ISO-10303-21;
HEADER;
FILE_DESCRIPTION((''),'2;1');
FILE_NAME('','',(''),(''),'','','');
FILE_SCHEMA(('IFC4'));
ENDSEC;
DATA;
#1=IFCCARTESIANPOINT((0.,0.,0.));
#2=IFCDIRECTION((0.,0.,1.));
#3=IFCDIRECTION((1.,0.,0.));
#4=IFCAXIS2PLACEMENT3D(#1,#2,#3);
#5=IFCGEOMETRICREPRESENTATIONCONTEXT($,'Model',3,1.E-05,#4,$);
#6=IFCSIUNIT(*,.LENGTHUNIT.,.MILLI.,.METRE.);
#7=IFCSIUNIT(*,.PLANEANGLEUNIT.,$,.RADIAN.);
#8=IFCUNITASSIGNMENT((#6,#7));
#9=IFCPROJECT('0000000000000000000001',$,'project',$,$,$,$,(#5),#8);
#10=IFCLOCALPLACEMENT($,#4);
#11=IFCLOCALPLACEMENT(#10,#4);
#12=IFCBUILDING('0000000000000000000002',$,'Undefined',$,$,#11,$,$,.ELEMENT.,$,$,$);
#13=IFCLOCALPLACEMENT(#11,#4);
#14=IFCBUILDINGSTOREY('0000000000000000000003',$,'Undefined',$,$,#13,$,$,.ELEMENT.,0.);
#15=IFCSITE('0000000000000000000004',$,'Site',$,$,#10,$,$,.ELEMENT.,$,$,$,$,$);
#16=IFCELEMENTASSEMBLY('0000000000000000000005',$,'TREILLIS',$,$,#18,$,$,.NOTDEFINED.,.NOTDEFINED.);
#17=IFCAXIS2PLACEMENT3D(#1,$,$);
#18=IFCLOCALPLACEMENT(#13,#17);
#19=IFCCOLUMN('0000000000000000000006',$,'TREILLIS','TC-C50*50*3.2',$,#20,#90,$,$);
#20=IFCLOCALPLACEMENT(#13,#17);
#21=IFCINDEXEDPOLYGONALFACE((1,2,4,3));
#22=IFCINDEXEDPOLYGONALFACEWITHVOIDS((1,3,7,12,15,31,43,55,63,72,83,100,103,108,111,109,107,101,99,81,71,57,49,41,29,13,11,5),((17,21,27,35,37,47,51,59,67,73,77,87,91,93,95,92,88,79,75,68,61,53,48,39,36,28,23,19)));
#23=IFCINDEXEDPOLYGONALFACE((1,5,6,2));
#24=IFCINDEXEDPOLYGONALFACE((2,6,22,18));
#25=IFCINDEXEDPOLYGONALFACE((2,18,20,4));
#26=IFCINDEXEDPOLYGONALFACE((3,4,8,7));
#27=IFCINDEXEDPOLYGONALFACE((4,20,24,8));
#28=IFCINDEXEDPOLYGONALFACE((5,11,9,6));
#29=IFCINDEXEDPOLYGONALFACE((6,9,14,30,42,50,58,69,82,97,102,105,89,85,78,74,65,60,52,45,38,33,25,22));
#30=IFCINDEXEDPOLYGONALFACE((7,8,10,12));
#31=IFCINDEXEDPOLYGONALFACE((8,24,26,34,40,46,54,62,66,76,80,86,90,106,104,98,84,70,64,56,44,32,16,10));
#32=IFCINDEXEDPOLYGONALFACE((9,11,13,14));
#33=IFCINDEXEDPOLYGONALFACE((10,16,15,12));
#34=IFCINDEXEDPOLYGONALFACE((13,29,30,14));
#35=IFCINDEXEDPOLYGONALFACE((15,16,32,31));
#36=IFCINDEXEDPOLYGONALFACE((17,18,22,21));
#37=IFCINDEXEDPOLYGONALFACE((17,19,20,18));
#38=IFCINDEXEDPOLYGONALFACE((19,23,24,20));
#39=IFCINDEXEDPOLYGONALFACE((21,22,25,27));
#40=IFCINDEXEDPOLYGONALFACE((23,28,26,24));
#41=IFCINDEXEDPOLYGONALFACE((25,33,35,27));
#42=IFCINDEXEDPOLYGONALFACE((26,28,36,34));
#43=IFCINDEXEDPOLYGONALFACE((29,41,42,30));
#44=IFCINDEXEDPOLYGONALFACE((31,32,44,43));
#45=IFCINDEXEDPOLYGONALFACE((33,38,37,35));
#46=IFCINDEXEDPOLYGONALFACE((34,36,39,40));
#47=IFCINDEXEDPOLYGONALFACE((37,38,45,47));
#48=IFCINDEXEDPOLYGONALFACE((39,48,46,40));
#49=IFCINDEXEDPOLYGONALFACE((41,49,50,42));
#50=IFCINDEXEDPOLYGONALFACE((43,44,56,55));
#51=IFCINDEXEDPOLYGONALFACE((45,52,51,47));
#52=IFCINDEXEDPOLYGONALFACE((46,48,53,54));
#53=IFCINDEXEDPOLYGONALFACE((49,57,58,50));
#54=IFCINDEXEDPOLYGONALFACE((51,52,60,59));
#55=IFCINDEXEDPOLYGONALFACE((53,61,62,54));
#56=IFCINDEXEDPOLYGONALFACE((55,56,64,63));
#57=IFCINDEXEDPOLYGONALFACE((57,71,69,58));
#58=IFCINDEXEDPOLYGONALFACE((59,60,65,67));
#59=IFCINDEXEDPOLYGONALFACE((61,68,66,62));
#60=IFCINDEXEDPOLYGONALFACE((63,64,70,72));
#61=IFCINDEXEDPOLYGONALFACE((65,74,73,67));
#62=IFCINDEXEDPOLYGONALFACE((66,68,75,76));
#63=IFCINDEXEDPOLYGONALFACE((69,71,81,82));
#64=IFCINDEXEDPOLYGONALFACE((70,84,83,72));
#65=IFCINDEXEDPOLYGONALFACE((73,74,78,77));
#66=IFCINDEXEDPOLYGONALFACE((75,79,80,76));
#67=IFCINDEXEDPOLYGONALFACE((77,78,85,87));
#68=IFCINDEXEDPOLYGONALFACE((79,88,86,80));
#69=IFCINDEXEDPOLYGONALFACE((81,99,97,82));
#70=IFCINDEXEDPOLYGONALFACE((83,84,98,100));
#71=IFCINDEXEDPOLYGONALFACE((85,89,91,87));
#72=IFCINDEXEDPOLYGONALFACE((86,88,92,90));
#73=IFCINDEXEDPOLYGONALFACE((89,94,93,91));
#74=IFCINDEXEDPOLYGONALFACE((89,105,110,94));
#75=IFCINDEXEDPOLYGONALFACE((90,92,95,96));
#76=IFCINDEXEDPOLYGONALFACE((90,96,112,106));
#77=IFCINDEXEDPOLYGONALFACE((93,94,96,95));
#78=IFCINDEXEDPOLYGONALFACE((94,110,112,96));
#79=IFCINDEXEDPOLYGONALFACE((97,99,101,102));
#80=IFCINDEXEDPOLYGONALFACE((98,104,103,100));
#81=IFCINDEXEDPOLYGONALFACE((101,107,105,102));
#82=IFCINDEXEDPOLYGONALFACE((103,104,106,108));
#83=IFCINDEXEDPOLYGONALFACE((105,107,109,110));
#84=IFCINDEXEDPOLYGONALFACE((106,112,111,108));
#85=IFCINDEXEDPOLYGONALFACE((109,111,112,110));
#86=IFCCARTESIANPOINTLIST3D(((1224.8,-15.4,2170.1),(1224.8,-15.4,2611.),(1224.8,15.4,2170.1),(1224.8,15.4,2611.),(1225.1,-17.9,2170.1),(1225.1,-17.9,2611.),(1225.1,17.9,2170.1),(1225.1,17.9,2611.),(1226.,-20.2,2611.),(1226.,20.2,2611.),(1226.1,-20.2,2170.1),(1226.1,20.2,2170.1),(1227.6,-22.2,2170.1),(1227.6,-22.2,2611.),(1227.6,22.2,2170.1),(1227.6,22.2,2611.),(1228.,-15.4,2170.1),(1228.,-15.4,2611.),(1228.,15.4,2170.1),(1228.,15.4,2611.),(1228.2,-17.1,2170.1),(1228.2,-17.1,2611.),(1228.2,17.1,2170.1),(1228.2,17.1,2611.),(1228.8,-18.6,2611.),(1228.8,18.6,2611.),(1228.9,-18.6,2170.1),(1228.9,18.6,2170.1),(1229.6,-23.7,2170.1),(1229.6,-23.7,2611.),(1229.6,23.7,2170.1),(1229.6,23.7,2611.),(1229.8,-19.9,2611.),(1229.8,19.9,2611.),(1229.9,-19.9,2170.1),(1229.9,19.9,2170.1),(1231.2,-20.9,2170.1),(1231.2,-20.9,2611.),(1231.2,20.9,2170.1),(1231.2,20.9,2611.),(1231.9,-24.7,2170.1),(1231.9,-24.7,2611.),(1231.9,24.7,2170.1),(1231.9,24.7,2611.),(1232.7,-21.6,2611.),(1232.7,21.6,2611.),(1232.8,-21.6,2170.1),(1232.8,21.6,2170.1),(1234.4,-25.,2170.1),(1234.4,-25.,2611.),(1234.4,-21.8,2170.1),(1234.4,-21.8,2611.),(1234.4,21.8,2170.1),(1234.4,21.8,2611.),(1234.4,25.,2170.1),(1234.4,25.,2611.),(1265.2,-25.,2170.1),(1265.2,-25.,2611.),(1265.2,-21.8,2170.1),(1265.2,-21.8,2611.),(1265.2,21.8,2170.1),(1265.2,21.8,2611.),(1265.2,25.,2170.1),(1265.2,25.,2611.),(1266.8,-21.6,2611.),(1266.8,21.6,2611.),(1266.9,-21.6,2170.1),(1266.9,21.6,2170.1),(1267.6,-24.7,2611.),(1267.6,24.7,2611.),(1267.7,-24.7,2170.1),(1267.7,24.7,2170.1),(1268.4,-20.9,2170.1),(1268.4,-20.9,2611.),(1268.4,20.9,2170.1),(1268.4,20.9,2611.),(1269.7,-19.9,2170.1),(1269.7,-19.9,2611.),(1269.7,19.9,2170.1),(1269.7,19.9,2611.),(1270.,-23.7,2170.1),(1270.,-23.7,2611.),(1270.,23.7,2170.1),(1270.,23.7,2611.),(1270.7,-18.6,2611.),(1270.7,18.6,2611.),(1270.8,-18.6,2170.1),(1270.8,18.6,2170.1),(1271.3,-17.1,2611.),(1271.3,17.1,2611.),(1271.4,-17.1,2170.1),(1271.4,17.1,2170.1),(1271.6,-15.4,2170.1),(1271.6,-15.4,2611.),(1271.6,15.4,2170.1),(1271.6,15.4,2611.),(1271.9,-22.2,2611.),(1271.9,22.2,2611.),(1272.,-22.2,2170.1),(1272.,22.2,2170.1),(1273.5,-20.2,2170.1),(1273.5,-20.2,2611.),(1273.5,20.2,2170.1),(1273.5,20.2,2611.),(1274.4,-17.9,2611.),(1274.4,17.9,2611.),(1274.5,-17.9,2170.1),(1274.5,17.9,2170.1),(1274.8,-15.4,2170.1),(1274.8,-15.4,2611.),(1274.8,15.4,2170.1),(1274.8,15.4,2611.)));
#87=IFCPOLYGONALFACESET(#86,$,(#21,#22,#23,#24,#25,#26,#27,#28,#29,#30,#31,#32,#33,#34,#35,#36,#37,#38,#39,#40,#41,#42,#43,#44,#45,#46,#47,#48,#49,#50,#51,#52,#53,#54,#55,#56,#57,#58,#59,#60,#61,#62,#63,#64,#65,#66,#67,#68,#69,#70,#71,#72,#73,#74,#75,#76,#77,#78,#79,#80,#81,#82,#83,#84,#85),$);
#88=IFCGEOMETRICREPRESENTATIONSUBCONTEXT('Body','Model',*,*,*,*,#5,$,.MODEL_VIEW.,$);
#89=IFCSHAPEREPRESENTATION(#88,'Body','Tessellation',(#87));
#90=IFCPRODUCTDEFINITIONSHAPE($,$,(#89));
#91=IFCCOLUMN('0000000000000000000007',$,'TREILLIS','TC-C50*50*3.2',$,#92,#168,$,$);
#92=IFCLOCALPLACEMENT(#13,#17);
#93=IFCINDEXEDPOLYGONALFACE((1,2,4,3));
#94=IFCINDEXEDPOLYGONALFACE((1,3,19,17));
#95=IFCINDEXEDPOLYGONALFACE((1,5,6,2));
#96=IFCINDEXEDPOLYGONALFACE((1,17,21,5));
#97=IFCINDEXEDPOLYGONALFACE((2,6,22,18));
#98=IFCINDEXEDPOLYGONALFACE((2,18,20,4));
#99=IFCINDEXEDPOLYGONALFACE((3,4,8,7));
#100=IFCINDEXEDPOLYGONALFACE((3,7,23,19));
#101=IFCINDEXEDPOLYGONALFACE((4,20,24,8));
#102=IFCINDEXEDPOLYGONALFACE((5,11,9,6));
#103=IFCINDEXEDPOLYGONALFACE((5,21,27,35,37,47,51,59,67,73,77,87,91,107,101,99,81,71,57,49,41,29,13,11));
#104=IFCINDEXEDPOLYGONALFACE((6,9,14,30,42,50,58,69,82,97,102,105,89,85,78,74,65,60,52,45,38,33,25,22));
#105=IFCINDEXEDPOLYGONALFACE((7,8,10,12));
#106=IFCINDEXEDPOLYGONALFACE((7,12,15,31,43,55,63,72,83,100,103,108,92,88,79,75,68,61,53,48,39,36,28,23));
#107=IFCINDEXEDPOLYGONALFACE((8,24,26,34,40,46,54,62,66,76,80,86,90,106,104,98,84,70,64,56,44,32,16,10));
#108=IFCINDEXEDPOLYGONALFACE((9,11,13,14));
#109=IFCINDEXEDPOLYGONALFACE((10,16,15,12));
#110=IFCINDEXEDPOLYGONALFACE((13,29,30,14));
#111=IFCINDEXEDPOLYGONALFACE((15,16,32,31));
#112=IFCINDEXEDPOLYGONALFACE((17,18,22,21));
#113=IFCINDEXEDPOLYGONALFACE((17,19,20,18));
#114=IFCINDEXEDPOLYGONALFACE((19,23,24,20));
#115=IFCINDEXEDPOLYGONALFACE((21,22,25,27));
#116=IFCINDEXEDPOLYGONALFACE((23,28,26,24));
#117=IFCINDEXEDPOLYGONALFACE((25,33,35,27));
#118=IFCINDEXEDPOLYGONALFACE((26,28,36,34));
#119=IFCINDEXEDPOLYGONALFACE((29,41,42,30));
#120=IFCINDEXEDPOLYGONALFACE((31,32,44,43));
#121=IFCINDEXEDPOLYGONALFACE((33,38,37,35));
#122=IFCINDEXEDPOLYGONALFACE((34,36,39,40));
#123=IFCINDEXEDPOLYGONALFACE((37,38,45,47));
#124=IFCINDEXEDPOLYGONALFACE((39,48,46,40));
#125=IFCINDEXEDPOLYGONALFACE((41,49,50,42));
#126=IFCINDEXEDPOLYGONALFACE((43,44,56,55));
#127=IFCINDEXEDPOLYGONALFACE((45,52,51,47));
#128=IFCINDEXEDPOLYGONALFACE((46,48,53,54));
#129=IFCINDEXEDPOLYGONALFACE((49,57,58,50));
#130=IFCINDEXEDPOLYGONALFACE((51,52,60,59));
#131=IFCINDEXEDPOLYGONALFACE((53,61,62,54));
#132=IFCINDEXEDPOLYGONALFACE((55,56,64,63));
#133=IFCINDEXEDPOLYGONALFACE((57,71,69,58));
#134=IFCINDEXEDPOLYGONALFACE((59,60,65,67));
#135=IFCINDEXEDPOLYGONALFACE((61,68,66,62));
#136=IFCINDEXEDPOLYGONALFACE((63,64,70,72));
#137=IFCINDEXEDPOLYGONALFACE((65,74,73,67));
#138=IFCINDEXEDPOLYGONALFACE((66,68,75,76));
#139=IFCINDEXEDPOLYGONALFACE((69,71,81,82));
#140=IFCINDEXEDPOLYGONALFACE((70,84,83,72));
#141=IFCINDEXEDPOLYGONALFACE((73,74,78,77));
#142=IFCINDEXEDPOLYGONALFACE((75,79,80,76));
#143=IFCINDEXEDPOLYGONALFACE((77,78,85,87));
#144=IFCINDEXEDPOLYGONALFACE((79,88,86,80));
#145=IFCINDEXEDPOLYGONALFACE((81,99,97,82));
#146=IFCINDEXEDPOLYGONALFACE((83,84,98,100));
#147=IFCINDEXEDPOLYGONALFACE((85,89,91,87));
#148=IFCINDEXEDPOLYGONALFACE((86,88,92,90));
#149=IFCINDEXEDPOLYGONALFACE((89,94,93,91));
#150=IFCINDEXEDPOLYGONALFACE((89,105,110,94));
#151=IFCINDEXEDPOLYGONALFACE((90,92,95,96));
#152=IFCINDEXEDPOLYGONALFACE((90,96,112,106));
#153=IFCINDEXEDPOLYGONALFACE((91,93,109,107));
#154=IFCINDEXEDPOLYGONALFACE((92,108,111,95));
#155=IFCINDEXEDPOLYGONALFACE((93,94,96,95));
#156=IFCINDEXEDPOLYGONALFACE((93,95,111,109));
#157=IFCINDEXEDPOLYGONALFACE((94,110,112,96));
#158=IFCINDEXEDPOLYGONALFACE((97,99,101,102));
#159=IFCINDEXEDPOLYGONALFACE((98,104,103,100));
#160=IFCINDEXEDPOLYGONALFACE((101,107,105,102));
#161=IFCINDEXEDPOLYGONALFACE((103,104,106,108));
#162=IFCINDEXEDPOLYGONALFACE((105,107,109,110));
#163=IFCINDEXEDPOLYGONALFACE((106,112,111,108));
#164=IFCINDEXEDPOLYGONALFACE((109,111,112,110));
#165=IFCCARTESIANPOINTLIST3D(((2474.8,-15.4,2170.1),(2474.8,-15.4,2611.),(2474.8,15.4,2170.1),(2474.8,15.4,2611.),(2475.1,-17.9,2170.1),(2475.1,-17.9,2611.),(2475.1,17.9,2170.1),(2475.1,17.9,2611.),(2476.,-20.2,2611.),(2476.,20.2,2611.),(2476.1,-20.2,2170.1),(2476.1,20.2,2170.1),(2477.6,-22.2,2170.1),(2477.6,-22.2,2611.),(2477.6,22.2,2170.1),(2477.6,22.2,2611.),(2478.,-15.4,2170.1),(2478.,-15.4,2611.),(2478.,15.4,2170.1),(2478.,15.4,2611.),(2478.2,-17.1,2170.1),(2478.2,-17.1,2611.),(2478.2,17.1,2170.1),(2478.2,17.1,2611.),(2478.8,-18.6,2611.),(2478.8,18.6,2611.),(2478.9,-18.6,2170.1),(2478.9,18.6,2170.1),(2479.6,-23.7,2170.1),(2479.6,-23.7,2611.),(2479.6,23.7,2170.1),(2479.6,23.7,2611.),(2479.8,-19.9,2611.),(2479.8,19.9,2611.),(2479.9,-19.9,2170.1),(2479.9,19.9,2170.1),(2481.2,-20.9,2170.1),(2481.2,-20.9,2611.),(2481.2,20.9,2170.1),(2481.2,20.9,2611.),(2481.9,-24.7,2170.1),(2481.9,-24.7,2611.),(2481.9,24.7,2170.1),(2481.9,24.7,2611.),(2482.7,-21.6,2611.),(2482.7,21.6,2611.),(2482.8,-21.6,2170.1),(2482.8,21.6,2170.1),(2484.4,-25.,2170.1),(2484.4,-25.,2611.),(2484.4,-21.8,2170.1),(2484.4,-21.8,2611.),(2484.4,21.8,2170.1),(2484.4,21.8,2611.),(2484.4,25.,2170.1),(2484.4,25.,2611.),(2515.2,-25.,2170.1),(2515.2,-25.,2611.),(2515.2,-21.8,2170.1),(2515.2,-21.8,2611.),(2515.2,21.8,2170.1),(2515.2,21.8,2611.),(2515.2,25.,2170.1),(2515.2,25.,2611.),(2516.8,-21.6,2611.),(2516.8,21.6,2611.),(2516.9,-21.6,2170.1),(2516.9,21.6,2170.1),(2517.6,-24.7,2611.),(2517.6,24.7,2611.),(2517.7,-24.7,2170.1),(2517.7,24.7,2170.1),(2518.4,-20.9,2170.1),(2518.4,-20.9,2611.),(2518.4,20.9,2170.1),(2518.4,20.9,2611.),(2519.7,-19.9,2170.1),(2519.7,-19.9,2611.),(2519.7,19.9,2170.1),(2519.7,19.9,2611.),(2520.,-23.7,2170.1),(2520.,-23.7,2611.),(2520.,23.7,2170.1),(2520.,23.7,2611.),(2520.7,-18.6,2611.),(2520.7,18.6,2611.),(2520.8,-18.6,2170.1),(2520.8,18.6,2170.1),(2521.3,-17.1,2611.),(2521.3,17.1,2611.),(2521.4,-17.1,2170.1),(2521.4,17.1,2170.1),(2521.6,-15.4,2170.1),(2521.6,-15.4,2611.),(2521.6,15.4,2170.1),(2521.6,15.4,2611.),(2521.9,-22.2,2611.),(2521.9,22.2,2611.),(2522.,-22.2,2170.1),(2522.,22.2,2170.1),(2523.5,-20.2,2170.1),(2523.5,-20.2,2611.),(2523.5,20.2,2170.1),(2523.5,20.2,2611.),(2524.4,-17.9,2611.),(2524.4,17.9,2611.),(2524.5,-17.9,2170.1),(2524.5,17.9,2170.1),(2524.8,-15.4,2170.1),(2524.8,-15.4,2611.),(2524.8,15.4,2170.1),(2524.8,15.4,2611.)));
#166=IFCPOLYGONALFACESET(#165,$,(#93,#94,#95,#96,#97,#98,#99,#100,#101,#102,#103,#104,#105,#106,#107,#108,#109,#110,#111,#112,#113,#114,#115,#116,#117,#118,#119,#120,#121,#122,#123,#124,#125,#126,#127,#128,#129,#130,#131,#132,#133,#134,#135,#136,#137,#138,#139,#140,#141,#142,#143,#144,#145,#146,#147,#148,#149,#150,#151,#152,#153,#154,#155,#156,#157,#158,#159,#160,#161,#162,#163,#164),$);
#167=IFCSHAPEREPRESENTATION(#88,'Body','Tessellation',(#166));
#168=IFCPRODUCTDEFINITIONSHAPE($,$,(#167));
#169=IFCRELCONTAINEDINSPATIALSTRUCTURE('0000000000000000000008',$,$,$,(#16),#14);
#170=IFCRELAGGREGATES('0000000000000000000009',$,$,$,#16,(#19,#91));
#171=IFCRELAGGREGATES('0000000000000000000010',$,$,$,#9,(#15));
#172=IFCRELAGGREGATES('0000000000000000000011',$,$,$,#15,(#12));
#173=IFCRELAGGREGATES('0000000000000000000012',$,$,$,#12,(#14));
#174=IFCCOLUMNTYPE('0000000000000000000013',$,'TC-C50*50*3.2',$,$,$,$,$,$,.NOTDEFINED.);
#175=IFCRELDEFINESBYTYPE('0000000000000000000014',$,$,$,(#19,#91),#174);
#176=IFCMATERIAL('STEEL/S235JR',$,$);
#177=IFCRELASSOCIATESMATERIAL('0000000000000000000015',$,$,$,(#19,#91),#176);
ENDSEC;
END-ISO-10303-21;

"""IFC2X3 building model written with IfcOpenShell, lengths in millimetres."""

from ifc_helpers import new_model, si_unit, frame, origin_with_axes, origin_2d_with_axis, place, context, subcontext, project, spatial, hollow_rectangle, extrude, clip, halfspace, material, type_object, element, aggregate, save


model = new_model("IFC2X3")

# Units and contexts
model_context = context("Model", 3, precision=1e-05, world=origin_with_axes())
body_context = subcontext(model_context, "Body", "Model", "MODEL_VIEW")
ifc_project = project(units=[si_unit("LENGTHUNIT", "METRE", prefix="MILLI"), si_unit("PLANEANGLEUNIT", "RADIAN")], contexts=[model_context])

# Site, building, storey
site_placement = place(None, origin_with_axes())
site = spatial("IfcSite", under=ifc_project, at=site_placement, Name="Site", CompositionType="ELEMENT")
building_placement = place(site_placement, origin_with_axes())
building = spatial("IfcBuilding", under=site, at=building_placement, Name="Undefined", CompositionType="ELEMENT")
storey_placement = place(building_placement, origin_with_axes())
storey = spatial("IfcBuildingStorey", under=building, at=storey_placement, Name="Undefined", CompositionType="ELEMENT", Elevation=0.0)

# Shared definitions
ifc_material_1 = material(Name="STEEL/S235JR")

# Element assembly, columns
assembly_1_placement = place(storey_placement, origin_with_axes())
assembly_1 = element("IfcElementAssembly", 1, at=assembly_1_placement, inside=storey, Name="TREILLIS", AssemblyPlace="NOTDEFINED", PredefinedType="NOTDEFINED")
column_type_1 = type_object("IfcColumnType", Name="TC-C50*50*3.2", PredefinedType="NOTDEFINED")
column_1_placement = place(assembly_1_placement, frame((1249.8, 0.0, 2170.1), z_axis=(-0.000141, 0.0, 1.0), x_axis=(1.0, 0.0, 0.000141)))
column_1 = element("IfcColumn", 2, at=column_1_placement, type_object=column_type_1, material=ifc_material_1, Name="TREILLIS", Description="TC-C50*50*3.2", context=body_context, shape_type="Clipping", body=[
    clip(extrude(hollow_rectangle(XDim=50.0, YDim=50.0, WallThickness=3.2, InnerFilletRadius=6.4, OuterFilletRadius=9.6, at=origin_2d_with_axis()), frame((0.0, 0.0, 474.9), z_axis=(0.0, 0.0, -1.0), x_axis=(0.0, 1.0, 0.0)), (0.0, 0.0, 1.0), 474.9), halfspace(frame((-24.8, 25.0, 440.9), z_axis=(0.000141, 0.0, 1.0), x_axis=(1.0, 0.0, -0.000141)), False)),
])
column_2_placement = place(assembly_1_placement, frame((2499.8, 0.0, 2145.1), z_axis=(-0.000134, 0.0, 1.0), x_axis=(1.0, 0.0, 0.000134)))
column_2 = element("IfcColumn", 3, at=column_2_placement, type_object=column_type_1, material=ifc_material_1, Name="TREILLIS", Description="TC-C50*50*3.2", context=body_context, shape_type="Clipping", body=[
    clip(clip(extrude(hollow_rectangle(XDim=50.0, YDim=50.0, WallThickness=3.2, InnerFilletRadius=6.4, OuterFilletRadius=9.6, at=origin_2d_with_axis()), frame((0.0, 0.0, 500.0), z_axis=(0.0, 0.0, -1.0), x_axis=(0.0, 1.0, 0.0)), (0.0, 0.0, 1.0), 500.0), halfspace(frame((-24.8, -25.0, 25.0), z_axis=(-0.000134, 0.0, -1.0), x_axis=(1.0, 0.0, -0.000134)), False)), halfspace(frame((-24.8, 25.0, 465.9), z_axis=(0.000134, 0.0, 1.0), x_axis=(1.0, 0.0, -0.000134)), False)),
])

aggregate(assembly_1, [column_1, column_2])

save(model, "model.ifc")
